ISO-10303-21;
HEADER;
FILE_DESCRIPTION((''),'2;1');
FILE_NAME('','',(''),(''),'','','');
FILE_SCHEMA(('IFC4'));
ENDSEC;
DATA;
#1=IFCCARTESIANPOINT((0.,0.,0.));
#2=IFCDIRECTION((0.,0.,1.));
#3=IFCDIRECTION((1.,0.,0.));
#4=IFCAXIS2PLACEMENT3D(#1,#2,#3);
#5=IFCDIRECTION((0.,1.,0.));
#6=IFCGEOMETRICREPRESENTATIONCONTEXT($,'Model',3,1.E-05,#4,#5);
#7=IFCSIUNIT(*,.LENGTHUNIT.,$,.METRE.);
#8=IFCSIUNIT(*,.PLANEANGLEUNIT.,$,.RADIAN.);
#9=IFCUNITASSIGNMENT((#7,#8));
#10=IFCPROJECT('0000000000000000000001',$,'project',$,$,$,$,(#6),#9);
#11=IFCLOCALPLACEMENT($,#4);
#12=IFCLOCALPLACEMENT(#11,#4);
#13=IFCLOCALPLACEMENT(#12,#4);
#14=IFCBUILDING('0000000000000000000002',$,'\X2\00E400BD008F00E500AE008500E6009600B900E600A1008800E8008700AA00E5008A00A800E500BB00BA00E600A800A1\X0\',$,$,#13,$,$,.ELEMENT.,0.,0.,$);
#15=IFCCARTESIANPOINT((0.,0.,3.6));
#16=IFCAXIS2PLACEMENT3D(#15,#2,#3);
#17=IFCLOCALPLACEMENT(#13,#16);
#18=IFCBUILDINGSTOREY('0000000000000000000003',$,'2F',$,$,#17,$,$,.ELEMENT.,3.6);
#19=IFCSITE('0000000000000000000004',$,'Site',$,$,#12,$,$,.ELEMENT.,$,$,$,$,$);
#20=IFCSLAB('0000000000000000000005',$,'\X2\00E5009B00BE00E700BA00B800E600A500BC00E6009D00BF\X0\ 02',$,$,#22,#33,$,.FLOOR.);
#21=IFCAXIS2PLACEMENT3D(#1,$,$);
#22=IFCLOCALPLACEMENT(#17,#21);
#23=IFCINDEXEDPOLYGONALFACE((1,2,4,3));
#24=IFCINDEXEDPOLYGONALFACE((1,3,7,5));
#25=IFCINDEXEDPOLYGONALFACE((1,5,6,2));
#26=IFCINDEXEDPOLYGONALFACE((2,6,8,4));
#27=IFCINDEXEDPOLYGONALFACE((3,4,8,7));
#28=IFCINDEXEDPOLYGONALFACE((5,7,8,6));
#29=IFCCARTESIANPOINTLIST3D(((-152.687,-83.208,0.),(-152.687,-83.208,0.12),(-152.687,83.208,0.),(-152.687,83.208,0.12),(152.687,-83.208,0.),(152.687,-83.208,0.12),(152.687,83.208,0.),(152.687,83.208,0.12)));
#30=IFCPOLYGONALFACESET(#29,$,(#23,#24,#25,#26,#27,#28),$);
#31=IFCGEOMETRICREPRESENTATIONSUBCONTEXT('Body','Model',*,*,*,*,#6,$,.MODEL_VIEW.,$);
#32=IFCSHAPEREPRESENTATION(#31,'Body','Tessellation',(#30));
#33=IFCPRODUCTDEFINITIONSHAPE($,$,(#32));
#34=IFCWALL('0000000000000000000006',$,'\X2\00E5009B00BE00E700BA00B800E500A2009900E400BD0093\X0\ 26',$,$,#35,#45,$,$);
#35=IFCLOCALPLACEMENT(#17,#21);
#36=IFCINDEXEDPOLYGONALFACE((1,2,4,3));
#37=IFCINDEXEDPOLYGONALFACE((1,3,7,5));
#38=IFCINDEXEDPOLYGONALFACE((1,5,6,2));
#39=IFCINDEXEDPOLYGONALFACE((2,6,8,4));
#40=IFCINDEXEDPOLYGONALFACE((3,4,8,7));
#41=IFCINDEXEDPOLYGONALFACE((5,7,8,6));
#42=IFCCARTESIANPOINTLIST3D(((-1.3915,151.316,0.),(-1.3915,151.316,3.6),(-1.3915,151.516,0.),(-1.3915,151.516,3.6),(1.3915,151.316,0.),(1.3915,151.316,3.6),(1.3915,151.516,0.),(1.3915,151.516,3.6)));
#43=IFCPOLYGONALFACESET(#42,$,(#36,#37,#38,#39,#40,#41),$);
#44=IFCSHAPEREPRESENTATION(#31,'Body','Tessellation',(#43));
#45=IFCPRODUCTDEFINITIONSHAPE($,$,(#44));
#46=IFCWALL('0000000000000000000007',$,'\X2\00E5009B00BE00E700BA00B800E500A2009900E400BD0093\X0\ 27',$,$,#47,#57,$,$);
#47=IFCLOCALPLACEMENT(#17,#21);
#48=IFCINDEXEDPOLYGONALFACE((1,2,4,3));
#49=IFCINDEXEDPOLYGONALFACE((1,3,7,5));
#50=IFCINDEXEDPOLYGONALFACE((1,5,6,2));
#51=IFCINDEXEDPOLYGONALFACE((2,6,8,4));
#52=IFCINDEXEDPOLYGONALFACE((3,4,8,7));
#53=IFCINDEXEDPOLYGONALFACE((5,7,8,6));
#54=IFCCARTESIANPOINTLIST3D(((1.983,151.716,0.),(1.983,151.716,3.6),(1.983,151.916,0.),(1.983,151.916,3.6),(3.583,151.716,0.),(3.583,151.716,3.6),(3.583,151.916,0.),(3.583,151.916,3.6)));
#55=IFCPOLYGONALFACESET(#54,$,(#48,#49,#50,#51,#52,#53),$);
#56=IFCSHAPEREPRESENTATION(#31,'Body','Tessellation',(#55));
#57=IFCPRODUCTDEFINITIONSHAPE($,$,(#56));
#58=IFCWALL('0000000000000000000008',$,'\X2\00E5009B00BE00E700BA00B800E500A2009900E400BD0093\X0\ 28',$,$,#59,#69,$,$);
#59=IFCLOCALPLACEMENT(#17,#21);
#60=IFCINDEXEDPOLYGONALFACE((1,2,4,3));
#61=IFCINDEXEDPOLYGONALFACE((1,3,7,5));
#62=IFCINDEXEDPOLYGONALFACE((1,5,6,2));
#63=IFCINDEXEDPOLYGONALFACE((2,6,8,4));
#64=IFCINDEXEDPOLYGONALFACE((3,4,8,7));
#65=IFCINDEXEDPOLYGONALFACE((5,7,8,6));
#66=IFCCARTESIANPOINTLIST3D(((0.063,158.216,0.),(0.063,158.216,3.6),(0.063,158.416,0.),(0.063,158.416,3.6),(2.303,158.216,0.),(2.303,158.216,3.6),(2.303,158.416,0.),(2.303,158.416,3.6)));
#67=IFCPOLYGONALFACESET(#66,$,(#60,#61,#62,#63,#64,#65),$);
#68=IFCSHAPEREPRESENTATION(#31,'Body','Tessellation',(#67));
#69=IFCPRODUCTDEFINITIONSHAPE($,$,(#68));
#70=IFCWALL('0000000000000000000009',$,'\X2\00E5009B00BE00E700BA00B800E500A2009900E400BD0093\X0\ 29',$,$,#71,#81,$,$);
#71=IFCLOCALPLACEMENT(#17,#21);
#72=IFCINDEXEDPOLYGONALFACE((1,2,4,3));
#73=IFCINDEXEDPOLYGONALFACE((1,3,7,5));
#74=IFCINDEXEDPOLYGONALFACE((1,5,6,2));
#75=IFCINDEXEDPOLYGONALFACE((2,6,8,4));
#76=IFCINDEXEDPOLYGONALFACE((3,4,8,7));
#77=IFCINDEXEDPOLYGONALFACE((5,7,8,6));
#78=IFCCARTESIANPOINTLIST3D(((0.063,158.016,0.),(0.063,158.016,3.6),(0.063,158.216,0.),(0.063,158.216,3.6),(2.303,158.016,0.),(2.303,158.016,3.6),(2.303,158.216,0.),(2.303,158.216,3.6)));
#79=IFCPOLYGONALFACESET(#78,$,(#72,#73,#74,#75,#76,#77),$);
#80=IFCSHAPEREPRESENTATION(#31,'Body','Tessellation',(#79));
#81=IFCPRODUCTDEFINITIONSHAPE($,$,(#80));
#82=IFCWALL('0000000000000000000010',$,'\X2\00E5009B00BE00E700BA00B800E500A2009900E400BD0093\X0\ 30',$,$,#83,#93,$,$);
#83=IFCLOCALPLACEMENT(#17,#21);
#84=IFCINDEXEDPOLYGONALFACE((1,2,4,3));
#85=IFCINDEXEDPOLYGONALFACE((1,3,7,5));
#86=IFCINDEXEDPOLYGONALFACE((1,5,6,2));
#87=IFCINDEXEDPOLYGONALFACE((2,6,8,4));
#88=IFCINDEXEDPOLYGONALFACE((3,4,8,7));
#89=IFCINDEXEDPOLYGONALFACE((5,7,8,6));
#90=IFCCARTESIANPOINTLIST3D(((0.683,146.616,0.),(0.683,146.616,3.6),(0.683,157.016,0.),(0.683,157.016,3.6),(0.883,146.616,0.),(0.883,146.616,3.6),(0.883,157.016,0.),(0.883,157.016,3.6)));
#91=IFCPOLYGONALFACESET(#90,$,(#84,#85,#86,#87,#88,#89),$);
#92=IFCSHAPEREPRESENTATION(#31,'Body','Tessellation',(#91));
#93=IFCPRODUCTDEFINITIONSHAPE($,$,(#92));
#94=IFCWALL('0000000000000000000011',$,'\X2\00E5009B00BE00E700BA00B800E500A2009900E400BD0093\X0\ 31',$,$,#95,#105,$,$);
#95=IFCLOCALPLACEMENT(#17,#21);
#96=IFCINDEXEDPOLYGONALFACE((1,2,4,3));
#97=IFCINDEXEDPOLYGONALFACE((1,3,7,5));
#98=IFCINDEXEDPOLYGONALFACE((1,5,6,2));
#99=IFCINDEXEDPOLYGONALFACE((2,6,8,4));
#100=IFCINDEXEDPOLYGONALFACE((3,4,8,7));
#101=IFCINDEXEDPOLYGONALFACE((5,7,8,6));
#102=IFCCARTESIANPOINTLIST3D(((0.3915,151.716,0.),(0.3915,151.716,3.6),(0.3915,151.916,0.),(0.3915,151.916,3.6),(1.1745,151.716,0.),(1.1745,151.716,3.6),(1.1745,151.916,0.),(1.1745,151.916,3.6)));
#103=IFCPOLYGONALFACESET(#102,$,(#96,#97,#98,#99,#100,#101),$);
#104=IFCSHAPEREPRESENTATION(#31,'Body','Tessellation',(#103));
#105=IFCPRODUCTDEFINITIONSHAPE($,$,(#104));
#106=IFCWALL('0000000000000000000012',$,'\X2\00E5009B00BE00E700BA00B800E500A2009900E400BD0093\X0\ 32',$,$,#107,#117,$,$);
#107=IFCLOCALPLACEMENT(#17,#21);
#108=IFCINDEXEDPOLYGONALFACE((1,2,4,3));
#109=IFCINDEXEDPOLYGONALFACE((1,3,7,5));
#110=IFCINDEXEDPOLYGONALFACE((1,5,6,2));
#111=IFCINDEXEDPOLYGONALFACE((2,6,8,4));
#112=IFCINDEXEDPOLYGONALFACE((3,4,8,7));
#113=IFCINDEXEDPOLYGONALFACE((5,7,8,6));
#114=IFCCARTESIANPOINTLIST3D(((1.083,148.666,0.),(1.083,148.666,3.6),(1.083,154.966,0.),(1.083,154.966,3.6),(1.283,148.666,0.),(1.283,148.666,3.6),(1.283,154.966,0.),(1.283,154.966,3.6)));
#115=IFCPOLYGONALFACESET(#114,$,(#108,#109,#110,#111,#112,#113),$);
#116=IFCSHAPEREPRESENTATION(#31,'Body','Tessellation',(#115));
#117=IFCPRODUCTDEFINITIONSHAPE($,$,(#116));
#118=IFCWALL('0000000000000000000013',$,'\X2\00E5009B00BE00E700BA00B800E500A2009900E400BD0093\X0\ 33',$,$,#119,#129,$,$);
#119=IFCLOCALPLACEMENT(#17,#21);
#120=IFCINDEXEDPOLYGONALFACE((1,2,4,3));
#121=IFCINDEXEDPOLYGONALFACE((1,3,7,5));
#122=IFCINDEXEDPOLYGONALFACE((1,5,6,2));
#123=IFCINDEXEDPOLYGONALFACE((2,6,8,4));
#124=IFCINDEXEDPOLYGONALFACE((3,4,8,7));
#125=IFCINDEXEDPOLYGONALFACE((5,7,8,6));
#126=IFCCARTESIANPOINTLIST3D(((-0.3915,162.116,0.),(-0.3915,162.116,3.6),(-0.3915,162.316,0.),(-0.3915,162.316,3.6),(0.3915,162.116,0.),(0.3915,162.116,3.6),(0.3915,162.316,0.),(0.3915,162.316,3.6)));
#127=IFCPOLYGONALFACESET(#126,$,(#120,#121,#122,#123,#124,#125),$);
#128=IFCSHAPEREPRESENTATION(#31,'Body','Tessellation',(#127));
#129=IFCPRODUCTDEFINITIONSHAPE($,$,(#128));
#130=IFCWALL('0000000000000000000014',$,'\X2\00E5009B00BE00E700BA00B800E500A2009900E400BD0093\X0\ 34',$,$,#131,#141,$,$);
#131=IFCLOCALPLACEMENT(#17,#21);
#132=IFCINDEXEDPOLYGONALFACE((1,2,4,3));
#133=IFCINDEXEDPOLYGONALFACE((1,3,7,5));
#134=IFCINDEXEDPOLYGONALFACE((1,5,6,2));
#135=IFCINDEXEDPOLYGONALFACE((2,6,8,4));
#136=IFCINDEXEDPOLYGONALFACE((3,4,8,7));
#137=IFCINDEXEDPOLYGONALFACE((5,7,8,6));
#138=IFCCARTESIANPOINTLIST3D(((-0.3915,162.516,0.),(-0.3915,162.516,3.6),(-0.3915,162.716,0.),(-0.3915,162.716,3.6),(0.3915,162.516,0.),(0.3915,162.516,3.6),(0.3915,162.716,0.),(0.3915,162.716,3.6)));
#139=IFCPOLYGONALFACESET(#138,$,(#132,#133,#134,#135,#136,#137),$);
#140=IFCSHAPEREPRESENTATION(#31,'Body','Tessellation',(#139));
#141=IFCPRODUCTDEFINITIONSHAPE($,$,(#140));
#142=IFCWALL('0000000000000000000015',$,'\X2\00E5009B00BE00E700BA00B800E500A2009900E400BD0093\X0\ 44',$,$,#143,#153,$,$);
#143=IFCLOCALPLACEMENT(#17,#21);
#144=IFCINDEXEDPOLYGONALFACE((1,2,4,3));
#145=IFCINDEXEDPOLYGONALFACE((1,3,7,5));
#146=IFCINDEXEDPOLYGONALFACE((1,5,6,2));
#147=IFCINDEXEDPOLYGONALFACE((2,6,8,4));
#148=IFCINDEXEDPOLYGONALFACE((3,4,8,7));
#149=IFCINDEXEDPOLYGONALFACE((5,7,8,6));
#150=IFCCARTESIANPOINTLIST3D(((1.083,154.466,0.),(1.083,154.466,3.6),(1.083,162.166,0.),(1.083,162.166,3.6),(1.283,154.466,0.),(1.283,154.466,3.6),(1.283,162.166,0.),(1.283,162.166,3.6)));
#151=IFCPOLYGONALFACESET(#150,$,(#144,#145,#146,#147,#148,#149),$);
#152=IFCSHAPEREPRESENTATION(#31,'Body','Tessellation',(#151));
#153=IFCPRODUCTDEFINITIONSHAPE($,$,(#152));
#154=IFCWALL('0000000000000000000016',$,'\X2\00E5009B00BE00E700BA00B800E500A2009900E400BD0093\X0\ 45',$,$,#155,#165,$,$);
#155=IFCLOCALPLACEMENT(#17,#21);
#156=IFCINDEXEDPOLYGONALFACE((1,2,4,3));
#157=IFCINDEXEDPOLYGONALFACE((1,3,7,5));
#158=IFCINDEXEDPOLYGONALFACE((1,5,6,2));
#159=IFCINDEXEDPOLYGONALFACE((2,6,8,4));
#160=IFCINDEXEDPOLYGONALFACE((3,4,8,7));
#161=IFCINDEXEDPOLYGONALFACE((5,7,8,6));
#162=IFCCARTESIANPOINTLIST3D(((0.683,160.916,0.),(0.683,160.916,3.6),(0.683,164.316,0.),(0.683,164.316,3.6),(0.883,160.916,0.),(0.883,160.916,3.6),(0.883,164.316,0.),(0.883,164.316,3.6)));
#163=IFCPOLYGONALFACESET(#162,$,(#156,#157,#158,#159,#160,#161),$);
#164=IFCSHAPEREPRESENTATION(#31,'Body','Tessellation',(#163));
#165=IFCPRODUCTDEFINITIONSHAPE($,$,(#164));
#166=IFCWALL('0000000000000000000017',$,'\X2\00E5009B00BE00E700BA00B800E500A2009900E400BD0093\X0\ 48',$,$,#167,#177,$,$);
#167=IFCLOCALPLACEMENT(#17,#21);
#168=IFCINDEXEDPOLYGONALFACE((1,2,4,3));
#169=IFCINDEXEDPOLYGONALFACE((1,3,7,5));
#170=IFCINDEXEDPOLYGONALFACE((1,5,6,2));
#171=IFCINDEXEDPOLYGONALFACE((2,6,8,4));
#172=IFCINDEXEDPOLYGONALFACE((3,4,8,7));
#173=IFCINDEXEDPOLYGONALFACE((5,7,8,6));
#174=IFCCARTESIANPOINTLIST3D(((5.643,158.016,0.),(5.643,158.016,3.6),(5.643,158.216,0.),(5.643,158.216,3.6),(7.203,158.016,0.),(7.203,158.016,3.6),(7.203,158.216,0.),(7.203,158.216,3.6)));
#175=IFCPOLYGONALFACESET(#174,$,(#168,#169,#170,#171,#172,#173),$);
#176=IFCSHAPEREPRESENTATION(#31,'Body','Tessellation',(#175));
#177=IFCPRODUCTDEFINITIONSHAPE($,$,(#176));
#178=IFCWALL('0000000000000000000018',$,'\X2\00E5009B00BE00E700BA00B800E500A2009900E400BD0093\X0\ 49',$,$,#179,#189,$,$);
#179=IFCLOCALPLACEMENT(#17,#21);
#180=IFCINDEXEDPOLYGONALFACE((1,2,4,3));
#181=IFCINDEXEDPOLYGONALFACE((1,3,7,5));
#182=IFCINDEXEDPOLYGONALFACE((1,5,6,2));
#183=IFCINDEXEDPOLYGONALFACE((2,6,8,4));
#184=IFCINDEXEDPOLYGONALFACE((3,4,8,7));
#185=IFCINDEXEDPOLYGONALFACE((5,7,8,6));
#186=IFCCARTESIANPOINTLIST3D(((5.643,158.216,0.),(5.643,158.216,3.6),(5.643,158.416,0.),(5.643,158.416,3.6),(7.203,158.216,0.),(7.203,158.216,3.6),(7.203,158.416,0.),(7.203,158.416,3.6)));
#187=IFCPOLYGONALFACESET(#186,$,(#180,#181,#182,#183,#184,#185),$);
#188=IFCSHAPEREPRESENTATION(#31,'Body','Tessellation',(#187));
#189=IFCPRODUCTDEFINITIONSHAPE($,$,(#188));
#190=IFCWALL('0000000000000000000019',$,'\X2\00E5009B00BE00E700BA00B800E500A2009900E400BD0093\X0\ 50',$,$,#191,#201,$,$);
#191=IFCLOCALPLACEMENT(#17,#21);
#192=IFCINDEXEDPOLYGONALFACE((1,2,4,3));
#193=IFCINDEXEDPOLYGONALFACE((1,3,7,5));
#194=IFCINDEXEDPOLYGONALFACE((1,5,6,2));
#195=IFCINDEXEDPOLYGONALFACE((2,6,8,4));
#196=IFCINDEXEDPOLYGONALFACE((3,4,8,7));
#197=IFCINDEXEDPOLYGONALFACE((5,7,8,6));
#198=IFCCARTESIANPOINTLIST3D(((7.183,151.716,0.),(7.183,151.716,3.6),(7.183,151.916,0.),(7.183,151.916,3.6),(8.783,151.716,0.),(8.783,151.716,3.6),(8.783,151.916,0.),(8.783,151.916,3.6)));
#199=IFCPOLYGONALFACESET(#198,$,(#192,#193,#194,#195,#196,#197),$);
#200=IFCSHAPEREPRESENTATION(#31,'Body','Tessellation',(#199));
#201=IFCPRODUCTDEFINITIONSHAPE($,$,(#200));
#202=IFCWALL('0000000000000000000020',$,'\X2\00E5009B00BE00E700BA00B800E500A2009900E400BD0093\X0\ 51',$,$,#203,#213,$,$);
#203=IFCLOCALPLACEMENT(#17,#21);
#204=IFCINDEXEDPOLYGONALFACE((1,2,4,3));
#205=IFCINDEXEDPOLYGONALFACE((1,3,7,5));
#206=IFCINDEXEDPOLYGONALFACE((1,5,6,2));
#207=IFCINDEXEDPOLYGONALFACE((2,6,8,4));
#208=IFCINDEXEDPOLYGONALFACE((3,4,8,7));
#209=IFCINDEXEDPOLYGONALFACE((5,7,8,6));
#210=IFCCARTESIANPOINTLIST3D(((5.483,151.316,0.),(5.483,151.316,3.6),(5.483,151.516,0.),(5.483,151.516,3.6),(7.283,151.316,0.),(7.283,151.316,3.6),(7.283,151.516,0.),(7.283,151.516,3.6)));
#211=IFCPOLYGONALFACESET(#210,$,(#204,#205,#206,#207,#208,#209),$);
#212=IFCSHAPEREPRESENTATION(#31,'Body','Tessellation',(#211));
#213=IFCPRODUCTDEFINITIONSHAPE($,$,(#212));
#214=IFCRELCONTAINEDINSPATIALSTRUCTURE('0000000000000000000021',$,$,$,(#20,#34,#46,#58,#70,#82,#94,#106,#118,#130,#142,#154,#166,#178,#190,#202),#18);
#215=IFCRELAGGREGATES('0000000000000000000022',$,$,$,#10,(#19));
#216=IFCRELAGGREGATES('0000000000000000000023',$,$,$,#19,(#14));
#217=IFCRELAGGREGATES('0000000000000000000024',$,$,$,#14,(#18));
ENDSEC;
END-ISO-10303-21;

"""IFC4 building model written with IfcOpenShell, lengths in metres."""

from ifc_helpers import new_model, si_unit, direction, frame, frame_2d, origin_with_axes, place, context, subcontext, project, spatial, rectangle, extrude, element, save


model = new_model("IFC4")

# Units and contexts
model_context = context("Model", 3, precision=1e-05, world=origin_with_axes(), true_north=direction((0.0, 1.0, 0.0)))
body_context = subcontext(model_context, "Body", "Model", "MODEL_VIEW")
ifc_project = project(units=[si_unit("LENGTHUNIT", "METRE"), si_unit("PLANEANGLEUNIT", "RADIAN")], contexts=[model_context])

# Site, building, storey
placement = place(None, origin_with_axes())
site_placement = place(placement, origin_with_axes())
site = spatial("IfcSite", under=ifc_project, at=site_placement, Name="Site", CompositionType="ELEMENT")
building_placement = place(site_placement, origin_with_axes())
building = spatial("IfcBuilding", under=site, at=building_placement, Name="ä½\u008få®\u0085æ\u0096¹æ¡\u0088è\u0087ªå\u008a¨å»ºæ¨¡", CompositionType="ELEMENT", ElevationOfRefHeight=0.0, ElevationOfTerrain=0.0)
storey_placement = place(building_placement, frame((0.0, 0.0, 3.6), z_axis=(0.0, 0.0, 1.0), x_axis=(1.0, 0.0, 0.0)))
storey = spatial("IfcBuildingStorey", under=building, at=storey_placement, Name="2F", CompositionType="ELEMENT", Elevation=3.6)

# Slab
slab_placement = place(storey_placement, origin_with_axes())
element("IfcSlab", 1, at=slab_placement, inside=storey, Name="å\u009b¾çº¸æ¥¼æ\u009d¿ 02", PredefinedType="FLOOR", context=body_context, shape_type="SweptSolid", body=[
    extrude(rectangle(XDim=305.374, YDim=166.416, at=frame_2d((0.0, 0.0), x_axis=(1.0, 0.0, 0.0))), frame((0.0, 0.0, 0.0), z_axis=(0.0, 0.0, 1.0)), (0.0, 0.0, 1.0), 0.12),
])

# Walls
wall_1_placement = place(storey_placement, frame((0.0, 151.416, 0.0), z_axis=(0.0, 0.0, 1.0), x_axis=(1.0, 0.0, 0.0)))
element("IfcWall", 2, at=wall_1_placement, inside=storey, Name="å\u009b¾çº¸å¢\u0099ä½\u0093 26", context=body_context, shape_type="SweptSolid", body=[
    extrude(rectangle(XDim=2.783, YDim=0.2, at=frame_2d((0.0, 0.0), x_axis=(1.0, 0.0, 0.0))), frame((0.0, 0.0, 0.0), z_axis=(0.0, 0.0, 1.0)), (0.0, 0.0, 1.0), 3.6),
])
wall_2_placement = place(storey_placement, frame((2.783, 151.816, 0.0), z_axis=(0.0, 0.0, 1.0), x_axis=(-1.0, 0.0, 0.0)))
element("IfcWall", 3, at=wall_2_placement, inside=storey, Name="å\u009b¾çº¸å¢\u0099ä½\u0093 27", context=body_context, shape_type="SweptSolid", body=[
    extrude(rectangle(XDim=1.6, YDim=0.2, at=frame_2d((0.0, 0.0), x_axis=(1.0, 0.0, 0.0))), frame((0.0, 0.0, 0.0), z_axis=(0.0, 0.0, 1.0)), (0.0, 0.0, 1.0), 3.6),
])
for number, where, z_axis, x_axis, name in (
    (4, (1.183, 158.316, 0.0), (0.0, 0.0, 1.0), (1.0, 0.0, 0.0), "å\u009b¾çº¸å¢\u0099ä½\u0093 28"),
    (5, (1.183, 158.116, 0.0), (0.0, 0.0, 1.0), (1.0, 0.0, 0.0), "å\u009b¾çº¸å¢\u0099ä½\u0093 29"),
):
    element("IfcWall", number, at=place(storey_placement, frame(where, z_axis=z_axis, x_axis=x_axis)), inside=storey, Name=name, context=body_context, shape_type="SweptSolid", body=[
        extrude(rectangle(XDim=2.24, YDim=0.2, at=frame_2d((0.0, 0.0), x_axis=(1.0, 0.0, 0.0))), frame((0.0, 0.0, 0.0), z_axis=(0.0, 0.0, 1.0)), (0.0, 0.0, 1.0), 3.6),
    ])
wall_3_placement = place(storey_placement, frame((0.783, 151.816, 0.0), z_axis=(0.0, 0.0, 1.0), x_axis=(0.0, 1.0, 0.0)))
element("IfcWall", 6, at=wall_3_placement, inside=storey, Name="å\u009b¾çº¸å¢\u0099ä½\u0093 30", context=body_context, shape_type="SweptSolid", body=[
    extrude(rectangle(XDim=10.4, YDim=0.2, at=frame_2d((0.0, 0.0), x_axis=(1.0, 0.0, 0.0))), frame((0.0, 0.0, 0.0), z_axis=(0.0, 0.0, 1.0)), (0.0, 0.0, 1.0), 3.6),
])
wall_4_placement = place(storey_placement, frame((0.783, 151.816, 0.0), z_axis=(0.0, 0.0, 1.0), x_axis=(-1.0, 0.0, 0.0)))
element("IfcWall", 7, at=wall_4_placement, inside=storey, Name="å\u009b¾çº¸å¢\u0099ä½\u0093 31", context=body_context, shape_type="SweptSolid", body=[
    extrude(rectangle(XDim=0.783, YDim=0.2, at=frame_2d((0.0, 0.0), x_axis=(1.0, 0.0, 0.0))), frame((0.0, 0.0, 0.0), z_axis=(0.0, 0.0, 1.0)), (0.0, 0.0, 1.0), 3.6),
])
wall_5_placement = place(storey_placement, frame((1.183, 151.816, 0.0), z_axis=(0.0, 0.0, 1.0), x_axis=(0.0, 1.0, 0.0)))
element("IfcWall", 8, at=wall_5_placement, inside=storey, Name="å\u009b¾çº¸å¢\u0099ä½\u0093 32", context=body_context, shape_type="SweptSolid", body=[
    extrude(rectangle(XDim=6.3, YDim=0.2, at=frame_2d((0.0, 0.0), x_axis=(1.0, 0.0, 0.0))), frame((0.0, 0.0, 0.0), z_axis=(0.0, 0.0, 1.0)), (0.0, 0.0, 1.0), 3.6),
])
for number, where, z_axis, x_axis, name in (
    (9, (0.0, 162.216, 0.0), (0.0, 0.0, 1.0), (1.0, 0.0, 0.0), "å\u009b¾çº¸å¢\u0099ä½\u0093 33"),
    (10, (0.0, 162.616, 0.0), (0.0, 0.0, 1.0), (1.0, 0.0, 0.0), "å\u009b¾çº¸å¢\u0099ä½\u0093 34"),
):
    element("IfcWall", number, at=place(storey_placement, frame(where, z_axis=z_axis, x_axis=x_axis)), inside=storey, Name=name, context=body_context, shape_type="SweptSolid", body=[
        extrude(rectangle(XDim=0.783, YDim=0.2, at=frame_2d((0.0, 0.0), x_axis=(1.0, 0.0, 0.0))), frame((0.0, 0.0, 0.0), z_axis=(0.0, 0.0, 1.0)), (0.0, 0.0, 1.0), 3.6),
    ])
wall_6_placement = place(storey_placement, frame((1.183, 158.316, 0.0), z_axis=(0.0, 0.0, 1.0), x_axis=(0.0, 1.0, 0.0)))
element("IfcWall", 11, at=wall_6_placement, inside=storey, Name="å\u009b¾çº¸å¢\u0099ä½\u0093 44", context=body_context, shape_type="SweptSolid", body=[
    extrude(rectangle(XDim=7.7, YDim=0.2, at=frame_2d((0.0, 0.0), x_axis=(1.0, 0.0, 0.0))), frame((0.0, 0.0, 0.0), z_axis=(0.0, 0.0, 1.0)), (0.0, 0.0, 1.0), 3.6),
])
wall_7_placement = place(storey_placement, frame((0.783, 162.616, 0.0), z_axis=(0.0, 0.0, 1.0), x_axis=(0.0, 1.0, 0.0)))
element("IfcWall", 12, at=wall_7_placement, inside=storey, Name="å\u009b¾çº¸å¢\u0099ä½\u0093 45", context=body_context, shape_type="SweptSolid", body=[
    extrude(rectangle(XDim=3.4, YDim=0.2, at=frame_2d((0.0, 0.0), x_axis=(1.0, 0.0, 0.0))), frame((0.0, 0.0, 0.0), z_axis=(0.0, 0.0, 1.0)), (0.0, 0.0, 1.0), 3.6),
])
for number, where, z_axis, x_axis, name in (
    (13, (6.423, 158.116, 0.0), (0.0, 0.0, 1.0), (1.0, 0.0, 0.0), "å\u009b¾çº¸å¢\u0099ä½\u0093 48"),
    (14, (6.423, 158.316, 0.0), (0.0, 0.0, 1.0), (1.0, 0.0, 0.0), "å\u009b¾çº¸å¢\u0099ä½\u0093 49"),
):
    element("IfcWall", number, at=place(storey_placement, frame(where, z_axis=z_axis, x_axis=x_axis)), inside=storey, Name=name, context=body_context, shape_type="SweptSolid", body=[
        extrude(rectangle(XDim=1.56, YDim=0.2, at=frame_2d((0.0, 0.0), x_axis=(1.0, 0.0, 0.0))), frame((0.0, 0.0, 0.0), z_axis=(0.0, 0.0, 1.0)), (0.0, 0.0, 1.0), 3.6),
    ])
wall_8_placement = place(storey_placement, frame((7.983, 151.816, 0.0), z_axis=(0.0, 0.0, 1.0), x_axis=(-1.0, 0.0, 0.0)))
element("IfcWall", 15, at=wall_8_placement, inside=storey, Name="å\u009b¾çº¸å¢\u0099ä½\u0093 50", context=body_context, shape_type="SweptSolid", body=[
    extrude(rectangle(XDim=1.6, YDim=0.2, at=frame_2d((0.0, 0.0), x_axis=(1.0, 0.0, 0.0))), frame((0.0, 0.0, 0.0), z_axis=(0.0, 0.0, 1.0)), (0.0, 0.0, 1.0), 3.6),
])
wall_9_placement = place(storey_placement, frame((6.383, 151.416, 0.0), z_axis=(0.0, 0.0, 1.0), x_axis=(1.0, 0.0, 0.0)))
element("IfcWall", 16, at=wall_9_placement, inside=storey, Name="å\u009b¾çº¸å¢\u0099ä½\u0093 51", context=body_context, shape_type="SweptSolid", body=[
    extrude(rectangle(XDim=1.8, YDim=0.2, at=frame_2d((0.0, 0.0), x_axis=(1.0, 0.0, 0.0))), frame((0.0, 0.0, 0.0), z_axis=(0.0, 0.0, 1.0)), (0.0, 0.0, 1.0), 3.6),
])

save(model, "model.ifc")
